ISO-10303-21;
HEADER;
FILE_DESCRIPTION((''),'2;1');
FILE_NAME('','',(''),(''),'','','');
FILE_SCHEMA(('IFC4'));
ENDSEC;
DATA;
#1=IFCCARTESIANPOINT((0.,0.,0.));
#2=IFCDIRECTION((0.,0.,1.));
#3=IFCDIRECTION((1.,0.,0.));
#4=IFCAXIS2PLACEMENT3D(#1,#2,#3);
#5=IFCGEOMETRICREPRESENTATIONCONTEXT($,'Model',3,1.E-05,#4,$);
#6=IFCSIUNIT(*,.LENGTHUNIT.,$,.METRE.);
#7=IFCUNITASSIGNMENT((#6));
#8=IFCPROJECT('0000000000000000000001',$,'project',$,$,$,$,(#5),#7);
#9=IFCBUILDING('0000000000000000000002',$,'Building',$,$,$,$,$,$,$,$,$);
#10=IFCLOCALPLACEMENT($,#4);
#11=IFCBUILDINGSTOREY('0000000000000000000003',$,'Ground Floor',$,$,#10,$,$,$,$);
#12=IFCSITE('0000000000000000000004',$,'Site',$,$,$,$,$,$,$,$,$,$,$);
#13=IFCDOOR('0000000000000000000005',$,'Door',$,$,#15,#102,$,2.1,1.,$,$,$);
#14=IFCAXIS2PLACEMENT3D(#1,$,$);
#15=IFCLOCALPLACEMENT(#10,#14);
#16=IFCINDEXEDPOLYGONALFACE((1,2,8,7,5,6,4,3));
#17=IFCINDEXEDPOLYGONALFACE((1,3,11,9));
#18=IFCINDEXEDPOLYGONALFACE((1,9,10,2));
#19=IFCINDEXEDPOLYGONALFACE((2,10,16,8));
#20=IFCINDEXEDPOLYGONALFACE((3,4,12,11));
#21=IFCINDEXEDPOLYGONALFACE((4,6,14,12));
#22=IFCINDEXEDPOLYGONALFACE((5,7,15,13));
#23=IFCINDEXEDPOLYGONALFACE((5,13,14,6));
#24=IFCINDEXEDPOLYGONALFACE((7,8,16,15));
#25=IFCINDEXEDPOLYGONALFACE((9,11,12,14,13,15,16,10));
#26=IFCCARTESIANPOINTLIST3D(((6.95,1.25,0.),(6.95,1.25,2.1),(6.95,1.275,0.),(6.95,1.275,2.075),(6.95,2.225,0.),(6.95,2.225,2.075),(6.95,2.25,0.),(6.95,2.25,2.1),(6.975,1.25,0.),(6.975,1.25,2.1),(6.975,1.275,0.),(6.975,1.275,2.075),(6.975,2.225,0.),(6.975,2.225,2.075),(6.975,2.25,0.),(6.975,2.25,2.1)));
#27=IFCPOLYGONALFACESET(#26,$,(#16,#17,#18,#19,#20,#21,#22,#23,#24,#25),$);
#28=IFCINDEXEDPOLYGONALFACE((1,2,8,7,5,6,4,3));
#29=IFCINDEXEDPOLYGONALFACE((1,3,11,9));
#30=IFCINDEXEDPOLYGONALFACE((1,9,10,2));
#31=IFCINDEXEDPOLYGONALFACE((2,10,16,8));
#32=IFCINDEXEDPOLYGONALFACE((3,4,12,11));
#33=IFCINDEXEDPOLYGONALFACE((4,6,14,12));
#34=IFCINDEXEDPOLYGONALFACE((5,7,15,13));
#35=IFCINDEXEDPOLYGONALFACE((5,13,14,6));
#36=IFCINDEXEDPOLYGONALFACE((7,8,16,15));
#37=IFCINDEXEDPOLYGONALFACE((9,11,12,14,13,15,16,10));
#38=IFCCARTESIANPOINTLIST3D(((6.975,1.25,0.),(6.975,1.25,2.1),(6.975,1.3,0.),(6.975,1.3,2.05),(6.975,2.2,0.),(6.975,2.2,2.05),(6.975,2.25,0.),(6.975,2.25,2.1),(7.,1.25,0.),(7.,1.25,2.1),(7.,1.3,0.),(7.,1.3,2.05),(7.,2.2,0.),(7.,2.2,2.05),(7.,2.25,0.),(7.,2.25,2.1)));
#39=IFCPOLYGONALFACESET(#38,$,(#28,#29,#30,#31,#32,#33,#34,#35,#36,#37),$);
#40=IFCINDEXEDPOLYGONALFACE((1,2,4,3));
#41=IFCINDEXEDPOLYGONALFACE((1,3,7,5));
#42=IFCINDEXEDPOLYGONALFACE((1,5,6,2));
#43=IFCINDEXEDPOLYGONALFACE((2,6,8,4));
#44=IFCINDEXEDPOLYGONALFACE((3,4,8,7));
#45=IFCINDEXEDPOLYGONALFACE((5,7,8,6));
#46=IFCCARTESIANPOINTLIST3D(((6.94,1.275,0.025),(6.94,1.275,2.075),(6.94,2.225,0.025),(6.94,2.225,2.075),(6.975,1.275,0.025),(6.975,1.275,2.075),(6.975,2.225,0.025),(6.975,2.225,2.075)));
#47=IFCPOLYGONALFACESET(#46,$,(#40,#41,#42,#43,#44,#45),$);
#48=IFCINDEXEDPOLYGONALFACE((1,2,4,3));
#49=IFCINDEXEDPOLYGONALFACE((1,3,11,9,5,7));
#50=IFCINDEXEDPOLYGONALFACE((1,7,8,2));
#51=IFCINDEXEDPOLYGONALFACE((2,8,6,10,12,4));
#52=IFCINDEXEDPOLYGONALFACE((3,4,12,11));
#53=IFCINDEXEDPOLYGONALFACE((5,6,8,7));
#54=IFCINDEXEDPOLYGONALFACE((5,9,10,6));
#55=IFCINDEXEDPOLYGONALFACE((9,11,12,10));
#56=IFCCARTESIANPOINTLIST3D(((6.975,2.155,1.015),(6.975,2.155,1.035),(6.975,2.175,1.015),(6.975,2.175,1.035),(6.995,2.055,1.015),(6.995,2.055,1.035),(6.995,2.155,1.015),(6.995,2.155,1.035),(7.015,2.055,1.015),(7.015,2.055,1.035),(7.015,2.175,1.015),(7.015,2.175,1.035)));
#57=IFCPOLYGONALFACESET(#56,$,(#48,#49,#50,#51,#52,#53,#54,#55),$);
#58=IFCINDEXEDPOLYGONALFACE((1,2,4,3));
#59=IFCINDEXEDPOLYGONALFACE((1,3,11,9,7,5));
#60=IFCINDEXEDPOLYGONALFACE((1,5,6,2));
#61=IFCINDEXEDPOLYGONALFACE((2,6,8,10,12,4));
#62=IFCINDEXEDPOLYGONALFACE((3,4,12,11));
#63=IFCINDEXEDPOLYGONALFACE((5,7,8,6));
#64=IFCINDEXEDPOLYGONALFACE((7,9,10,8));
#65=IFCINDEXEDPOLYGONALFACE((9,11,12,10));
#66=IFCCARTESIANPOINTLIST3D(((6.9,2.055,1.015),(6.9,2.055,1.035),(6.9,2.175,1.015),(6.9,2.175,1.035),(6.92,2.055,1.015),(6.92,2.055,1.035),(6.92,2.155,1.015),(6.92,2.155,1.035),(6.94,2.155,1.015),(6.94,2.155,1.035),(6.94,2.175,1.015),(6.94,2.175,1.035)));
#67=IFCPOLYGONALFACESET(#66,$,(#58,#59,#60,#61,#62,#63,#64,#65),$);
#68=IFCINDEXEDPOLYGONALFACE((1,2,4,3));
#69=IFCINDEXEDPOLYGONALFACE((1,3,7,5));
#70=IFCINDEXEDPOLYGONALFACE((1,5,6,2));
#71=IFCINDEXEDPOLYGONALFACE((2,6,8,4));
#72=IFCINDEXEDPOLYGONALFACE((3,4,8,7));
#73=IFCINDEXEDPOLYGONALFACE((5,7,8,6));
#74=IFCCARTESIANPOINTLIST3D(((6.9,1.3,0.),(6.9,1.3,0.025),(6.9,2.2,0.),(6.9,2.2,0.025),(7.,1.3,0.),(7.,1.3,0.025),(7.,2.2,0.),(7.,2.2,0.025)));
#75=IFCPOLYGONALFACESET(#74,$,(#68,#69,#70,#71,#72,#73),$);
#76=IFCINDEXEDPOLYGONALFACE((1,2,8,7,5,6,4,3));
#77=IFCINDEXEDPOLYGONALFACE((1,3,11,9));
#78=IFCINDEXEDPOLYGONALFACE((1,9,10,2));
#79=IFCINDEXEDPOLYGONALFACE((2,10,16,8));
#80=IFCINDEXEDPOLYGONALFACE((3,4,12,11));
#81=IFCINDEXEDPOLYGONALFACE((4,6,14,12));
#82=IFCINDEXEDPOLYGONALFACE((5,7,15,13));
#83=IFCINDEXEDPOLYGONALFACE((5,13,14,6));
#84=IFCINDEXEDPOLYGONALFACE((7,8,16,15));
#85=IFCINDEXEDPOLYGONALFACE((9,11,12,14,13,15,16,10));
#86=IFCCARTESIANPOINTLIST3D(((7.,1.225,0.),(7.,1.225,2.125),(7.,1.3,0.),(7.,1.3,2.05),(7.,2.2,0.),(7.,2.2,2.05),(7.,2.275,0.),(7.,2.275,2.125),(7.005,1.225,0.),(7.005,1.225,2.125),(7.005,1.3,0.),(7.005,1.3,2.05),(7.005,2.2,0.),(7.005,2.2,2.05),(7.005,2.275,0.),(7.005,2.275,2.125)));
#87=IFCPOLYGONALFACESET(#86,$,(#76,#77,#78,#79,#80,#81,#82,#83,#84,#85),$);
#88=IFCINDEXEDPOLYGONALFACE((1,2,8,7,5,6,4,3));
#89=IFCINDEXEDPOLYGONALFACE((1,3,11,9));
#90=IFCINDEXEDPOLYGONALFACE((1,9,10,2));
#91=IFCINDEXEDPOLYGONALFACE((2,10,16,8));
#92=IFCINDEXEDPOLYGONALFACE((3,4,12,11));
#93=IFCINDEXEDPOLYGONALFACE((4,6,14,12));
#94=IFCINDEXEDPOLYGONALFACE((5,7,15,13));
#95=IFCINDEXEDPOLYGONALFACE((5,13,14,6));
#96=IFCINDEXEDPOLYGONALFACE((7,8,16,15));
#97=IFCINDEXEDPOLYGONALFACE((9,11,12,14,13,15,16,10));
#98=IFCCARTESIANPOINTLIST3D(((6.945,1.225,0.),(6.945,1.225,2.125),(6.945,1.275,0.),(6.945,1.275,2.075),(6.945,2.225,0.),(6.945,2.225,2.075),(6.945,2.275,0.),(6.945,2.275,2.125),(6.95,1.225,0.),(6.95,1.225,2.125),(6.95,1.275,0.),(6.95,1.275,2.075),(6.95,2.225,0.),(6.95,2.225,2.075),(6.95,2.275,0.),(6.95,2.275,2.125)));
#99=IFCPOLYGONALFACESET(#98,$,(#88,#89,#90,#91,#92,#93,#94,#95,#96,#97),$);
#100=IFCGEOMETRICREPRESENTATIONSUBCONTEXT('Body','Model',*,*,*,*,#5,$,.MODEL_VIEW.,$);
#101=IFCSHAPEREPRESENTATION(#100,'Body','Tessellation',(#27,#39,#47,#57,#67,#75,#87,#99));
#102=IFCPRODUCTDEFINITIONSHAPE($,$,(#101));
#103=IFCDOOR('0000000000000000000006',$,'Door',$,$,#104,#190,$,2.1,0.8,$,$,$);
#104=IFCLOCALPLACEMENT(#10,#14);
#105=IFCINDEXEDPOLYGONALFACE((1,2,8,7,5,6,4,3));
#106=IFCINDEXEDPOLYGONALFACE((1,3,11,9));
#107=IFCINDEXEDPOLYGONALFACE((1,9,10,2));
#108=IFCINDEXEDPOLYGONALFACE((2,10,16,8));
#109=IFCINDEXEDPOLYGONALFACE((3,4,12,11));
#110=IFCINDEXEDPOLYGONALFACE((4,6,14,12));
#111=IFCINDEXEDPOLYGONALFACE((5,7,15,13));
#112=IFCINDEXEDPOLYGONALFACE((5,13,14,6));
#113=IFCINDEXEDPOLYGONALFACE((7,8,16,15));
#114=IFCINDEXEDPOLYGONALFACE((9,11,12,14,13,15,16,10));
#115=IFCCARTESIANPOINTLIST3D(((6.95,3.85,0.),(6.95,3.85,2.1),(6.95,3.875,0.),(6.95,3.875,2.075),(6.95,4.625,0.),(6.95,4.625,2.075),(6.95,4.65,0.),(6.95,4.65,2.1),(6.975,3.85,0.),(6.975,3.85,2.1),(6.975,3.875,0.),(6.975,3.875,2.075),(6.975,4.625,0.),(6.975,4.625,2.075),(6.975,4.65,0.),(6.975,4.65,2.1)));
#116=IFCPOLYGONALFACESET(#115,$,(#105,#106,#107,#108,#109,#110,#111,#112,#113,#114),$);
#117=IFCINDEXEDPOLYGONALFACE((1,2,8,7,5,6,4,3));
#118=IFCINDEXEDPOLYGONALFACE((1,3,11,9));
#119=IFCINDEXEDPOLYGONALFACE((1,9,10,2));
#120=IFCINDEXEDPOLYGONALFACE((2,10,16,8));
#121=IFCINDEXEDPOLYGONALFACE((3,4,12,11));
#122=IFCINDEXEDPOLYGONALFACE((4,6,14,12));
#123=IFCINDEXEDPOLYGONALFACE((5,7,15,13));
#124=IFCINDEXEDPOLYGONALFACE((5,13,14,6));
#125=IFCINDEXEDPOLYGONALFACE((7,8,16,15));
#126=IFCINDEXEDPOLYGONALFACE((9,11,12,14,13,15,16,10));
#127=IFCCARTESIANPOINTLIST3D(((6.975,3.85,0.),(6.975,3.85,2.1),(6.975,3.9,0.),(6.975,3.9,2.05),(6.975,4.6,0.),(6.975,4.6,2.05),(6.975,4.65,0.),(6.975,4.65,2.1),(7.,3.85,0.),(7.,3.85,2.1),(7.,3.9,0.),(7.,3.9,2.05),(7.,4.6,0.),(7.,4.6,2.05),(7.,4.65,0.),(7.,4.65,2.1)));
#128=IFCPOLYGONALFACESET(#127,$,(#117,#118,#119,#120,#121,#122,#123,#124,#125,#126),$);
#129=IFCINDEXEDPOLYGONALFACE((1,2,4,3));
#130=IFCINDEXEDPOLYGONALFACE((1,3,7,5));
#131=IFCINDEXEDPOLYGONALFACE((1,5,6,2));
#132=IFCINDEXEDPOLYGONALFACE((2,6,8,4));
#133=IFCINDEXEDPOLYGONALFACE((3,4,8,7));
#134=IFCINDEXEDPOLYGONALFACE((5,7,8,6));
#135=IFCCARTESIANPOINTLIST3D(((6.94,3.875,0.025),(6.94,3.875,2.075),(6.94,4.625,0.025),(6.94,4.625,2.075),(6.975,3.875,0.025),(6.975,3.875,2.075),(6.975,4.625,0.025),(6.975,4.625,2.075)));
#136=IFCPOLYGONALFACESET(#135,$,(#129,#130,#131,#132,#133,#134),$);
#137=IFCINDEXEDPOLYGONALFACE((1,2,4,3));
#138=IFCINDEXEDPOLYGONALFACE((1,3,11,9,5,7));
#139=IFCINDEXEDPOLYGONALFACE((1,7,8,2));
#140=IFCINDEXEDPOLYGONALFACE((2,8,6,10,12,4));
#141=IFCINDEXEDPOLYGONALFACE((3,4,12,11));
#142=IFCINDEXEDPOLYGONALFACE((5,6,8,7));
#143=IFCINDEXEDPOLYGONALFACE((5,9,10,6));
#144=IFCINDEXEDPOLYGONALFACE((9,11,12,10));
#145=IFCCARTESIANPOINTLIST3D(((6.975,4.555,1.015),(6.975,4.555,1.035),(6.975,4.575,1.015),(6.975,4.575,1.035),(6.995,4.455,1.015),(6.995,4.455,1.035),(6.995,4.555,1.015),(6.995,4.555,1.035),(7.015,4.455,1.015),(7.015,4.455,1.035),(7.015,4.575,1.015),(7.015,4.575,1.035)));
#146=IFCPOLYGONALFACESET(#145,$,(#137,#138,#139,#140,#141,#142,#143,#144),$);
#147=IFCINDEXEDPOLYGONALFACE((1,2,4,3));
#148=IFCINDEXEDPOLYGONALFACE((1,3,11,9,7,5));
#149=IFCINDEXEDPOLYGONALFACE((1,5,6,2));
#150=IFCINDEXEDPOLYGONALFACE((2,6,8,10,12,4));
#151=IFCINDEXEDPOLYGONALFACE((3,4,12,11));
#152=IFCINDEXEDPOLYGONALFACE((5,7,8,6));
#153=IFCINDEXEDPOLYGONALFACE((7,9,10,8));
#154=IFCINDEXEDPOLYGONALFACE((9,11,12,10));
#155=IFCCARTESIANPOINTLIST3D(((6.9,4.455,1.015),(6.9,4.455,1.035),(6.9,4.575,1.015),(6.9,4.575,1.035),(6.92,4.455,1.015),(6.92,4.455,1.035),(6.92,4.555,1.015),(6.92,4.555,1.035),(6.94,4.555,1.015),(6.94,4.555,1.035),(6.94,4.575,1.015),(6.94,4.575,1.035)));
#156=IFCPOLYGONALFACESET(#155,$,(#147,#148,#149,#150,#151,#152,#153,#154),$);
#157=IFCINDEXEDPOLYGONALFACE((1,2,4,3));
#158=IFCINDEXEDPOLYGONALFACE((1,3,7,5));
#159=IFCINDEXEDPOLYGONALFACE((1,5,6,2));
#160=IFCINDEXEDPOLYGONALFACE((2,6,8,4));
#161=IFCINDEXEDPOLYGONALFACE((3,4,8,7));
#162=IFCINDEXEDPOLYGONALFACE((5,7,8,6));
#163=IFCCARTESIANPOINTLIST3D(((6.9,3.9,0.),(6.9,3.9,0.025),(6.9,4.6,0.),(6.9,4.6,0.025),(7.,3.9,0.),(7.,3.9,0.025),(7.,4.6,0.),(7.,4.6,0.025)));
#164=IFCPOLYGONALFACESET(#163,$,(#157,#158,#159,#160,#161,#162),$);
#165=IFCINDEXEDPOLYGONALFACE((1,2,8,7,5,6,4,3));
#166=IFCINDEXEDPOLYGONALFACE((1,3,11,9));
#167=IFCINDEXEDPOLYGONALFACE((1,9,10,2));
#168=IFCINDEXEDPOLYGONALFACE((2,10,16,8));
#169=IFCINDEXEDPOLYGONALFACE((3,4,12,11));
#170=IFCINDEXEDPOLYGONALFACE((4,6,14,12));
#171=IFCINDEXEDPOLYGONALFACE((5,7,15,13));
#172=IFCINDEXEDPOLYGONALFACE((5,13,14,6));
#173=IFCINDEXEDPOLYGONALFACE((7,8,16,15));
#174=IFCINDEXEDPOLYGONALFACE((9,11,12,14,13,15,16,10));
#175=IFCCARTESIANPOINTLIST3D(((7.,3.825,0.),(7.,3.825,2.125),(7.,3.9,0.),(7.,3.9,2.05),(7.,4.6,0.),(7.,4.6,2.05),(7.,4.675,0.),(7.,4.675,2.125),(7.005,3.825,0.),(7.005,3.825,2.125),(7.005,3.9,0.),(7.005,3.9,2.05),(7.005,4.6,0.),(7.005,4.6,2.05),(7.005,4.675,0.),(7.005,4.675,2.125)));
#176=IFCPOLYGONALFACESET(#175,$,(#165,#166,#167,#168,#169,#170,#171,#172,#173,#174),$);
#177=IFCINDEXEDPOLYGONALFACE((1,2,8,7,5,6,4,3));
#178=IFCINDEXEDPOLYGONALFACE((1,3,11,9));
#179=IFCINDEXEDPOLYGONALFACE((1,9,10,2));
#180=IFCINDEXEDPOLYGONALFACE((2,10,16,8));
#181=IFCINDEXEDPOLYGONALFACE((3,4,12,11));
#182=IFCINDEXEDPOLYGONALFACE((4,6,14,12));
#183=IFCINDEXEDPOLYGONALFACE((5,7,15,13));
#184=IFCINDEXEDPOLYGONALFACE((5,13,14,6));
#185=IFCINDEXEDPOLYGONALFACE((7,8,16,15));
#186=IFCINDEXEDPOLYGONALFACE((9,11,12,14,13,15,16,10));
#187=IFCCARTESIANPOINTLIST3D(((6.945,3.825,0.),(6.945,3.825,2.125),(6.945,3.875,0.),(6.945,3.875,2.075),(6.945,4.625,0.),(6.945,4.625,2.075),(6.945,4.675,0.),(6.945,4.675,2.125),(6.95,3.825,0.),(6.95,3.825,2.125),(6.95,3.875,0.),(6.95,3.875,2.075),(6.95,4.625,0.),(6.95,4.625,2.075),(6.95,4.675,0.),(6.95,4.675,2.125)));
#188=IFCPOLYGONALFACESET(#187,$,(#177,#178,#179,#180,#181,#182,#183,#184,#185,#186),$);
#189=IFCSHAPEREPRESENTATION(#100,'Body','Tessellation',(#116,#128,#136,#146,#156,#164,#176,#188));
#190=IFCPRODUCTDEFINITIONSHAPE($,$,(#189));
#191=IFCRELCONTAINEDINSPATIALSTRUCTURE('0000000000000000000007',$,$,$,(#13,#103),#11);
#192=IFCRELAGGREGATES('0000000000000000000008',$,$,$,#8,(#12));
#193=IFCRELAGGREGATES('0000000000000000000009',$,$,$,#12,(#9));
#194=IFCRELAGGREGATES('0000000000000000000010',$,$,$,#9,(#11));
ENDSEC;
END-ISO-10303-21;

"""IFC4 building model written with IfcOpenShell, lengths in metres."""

from ifc_helpers import new_model, si_unit, frame, origin_with_axes, place, context, subcontext, project, spatial, line, indexed_curve, outline, extrude, element, save


model = new_model("IFC4")

# Units and contexts
model_context = context("Model", 3, precision=1e-05, world=origin_with_axes())
body_context = subcontext(model_context, "Body", "Model", "MODEL_VIEW")
ifc_project = project(units=[si_unit("LENGTHUNIT", "METRE")], contexts=[model_context])

# Site, building, storey
site = spatial("IfcSite", under=ifc_project, Name="Site")
building = spatial("IfcBuilding", under=site, Name="Building")
storey_placement = place(None, origin_with_axes())
storey = spatial("IfcBuildingStorey", under=building, at=storey_placement, Name="Ground Floor")

# Doors
door_1_placement = place(storey_placement, frame((7.0, 1.25, 0.0), z_axis=(0.0, 0.0, 1.0), x_axis=(0.0, 1.0, 0.0)))
element("IfcDoor", 1, at=door_1_placement, inside=storey, Name="Door", OverallHeight=2.1, OverallWidth=1.0, context=body_context, shape_type="SweptSolid", body=[
    extrude(outline(indexed_curve([(0.0, 0.0), (0.0, 2.1), (1.0, 2.1), (1.0, 0.0), (0.975, 0.0), (0.975, 2.075), (0.025, 2.075), (0.025, 0.0)], segments=[line(1, 2, 3, 4, 5, 6, 7, 8, 1)])), frame((0.0, 0.025, 0.0), z_axis=(0.0, -1.0, 0.0), x_axis=(1.0, 0.0, 0.0)), (0.0, 0.0, -1.0), 0.025),
    extrude(outline(indexed_curve([(0.0, 0.0), (0.0, 2.1), (1.0, 2.1), (1.0, 0.0), (0.95, 0.0), (0.95, 2.05), (0.05, 2.05), (0.05, 0.0)], segments=[line(1, 2, 3, 4, 5, 6, 7, 8, 1)])), frame((0.0, 0.0, 0.0), z_axis=(0.0, -1.0, 0.0), x_axis=(1.0, 0.0, 0.0)), (0.0, 0.0, -1.0), 0.025),
    extrude(outline(indexed_curve([(0.0, 0.0), (0.95, 0.0), (0.95, 0.035), (0.0, 0.035)], segments=[line(1, 2, 3, 4, 1)])), frame((0.025, 0.025, 0.025), z_axis=(0.0, 0.0, 1.0), x_axis=(1.0, 0.0, 0.0)), (0.0, 0.0, 1.0), 2.05),
    extrude(outline(indexed_curve([(0.0, 0.0), (0.0, -0.04), (-0.12, -0.04), (-0.12, -0.02), (-0.02, -0.02), (-0.02, 0.0)], segments=[line(1, 2, 3, 4, 5, 6, 1)])), frame((0.925, 0.025, 1.015), z_axis=(0.0, 0.0, 1.0), x_axis=(1.0, 0.0, 0.0)), (0.0, 0.0, 1.0), 0.02),
    extrude(outline(indexed_curve([(0.0, 0.0), (0.0, 0.04), (-0.12, 0.04), (-0.12, 0.02), (-0.02, 0.02), (-0.02, 0.0)], segments=[line(1, 2, 3, 4, 5, 6, 1)])), frame((0.925, 0.06, 1.015), z_axis=(0.0, 0.0, 1.0), x_axis=(1.0, 0.0, 0.0)), (0.0, 0.0, 1.0), 0.02),
    extrude(outline(indexed_curve([(0.0, 0.0), (0.9, 0.0), (0.9, 0.1), (0.0, 0.1)], segments=[line(1, 2, 3, 4, 1)])), frame((0.05, 0.0, 0.0), z_axis=(0.0, 0.0, 1.0), x_axis=(1.0, 0.0, 0.0)), (0.0, 0.0, 1.0), 0.025),
    extrude(outline(indexed_curve([(0.0, 0.0), (0.0, 2.125), (1.05, 2.125), (1.05, 0.0), (0.975, 0.0), (0.975, 2.05), (0.075, 2.05), (0.075, 0.0)], segments=[line(1, 2, 3, 4, 5, 6, 7, 8, 1)])), frame((-0.025, -0.005, 0.0), z_axis=(0.0, -1.0, 0.0), x_axis=(1.0, 0.0, 0.0)), (0.0, 0.0, -1.0), 0.005),
    extrude(outline(indexed_curve([(0.0, 0.0), (0.0, 2.125), (1.05, 2.125), (1.05, 0.0), (1.0, 0.0), (1.0, 2.075), (0.05, 2.075), (0.05, 0.0)], segments=[line(1, 2, 3, 4, 5, 6, 7, 8, 1)])), frame((-0.025, 0.05, 0.0), z_axis=(0.0, -1.0, 0.0), x_axis=(1.0, 0.0, 0.0)), (0.0, 0.0, -1.0), 0.005),
])
door_2_placement = place(storey_placement, frame((7.0, 3.85, 0.0), z_axis=(0.0, 0.0, 1.0), x_axis=(0.0, 1.0, 0.0)))
element("IfcDoor", 2, at=door_2_placement, inside=storey, Name="Door", OverallHeight=2.1, OverallWidth=0.8, context=body_context, shape_type="SweptSolid", body=[
    extrude(outline(indexed_curve([(0.0, 0.0), (0.0, 2.1), (0.8, 2.1), (0.8, 0.0), (0.775, 0.0), (0.775, 2.075), (0.025, 2.075), (0.025, 0.0)], segments=[line(1, 2, 3, 4, 5, 6, 7, 8, 1)])), frame((0.0, 0.025, 0.0), z_axis=(0.0, -1.0, 0.0), x_axis=(1.0, 0.0, 0.0)), (0.0, 0.0, -1.0), 0.025),
    extrude(outline(indexed_curve([(0.0, 0.0), (0.0, 2.1), (0.8, 2.1), (0.8, 0.0), (0.75, 0.0), (0.75, 2.05), (0.05, 2.05), (0.05, 0.0)], segments=[line(1, 2, 3, 4, 5, 6, 7, 8, 1)])), frame((0.0, 0.0, 0.0), z_axis=(0.0, -1.0, 0.0), x_axis=(1.0, 0.0, 0.0)), (0.0, 0.0, -1.0), 0.025),
    extrude(outline(indexed_curve([(0.0, 0.0), (0.75, 0.0), (0.75, 0.035), (0.0, 0.035)], segments=[line(1, 2, 3, 4, 1)])), frame((0.025, 0.025, 0.025), z_axis=(0.0, 0.0, 1.0), x_axis=(1.0, 0.0, 0.0)), (0.0, 0.0, 1.0), 2.05),
    extrude(outline(indexed_curve([(0.0, 0.0), (0.0, -0.04), (-0.12, -0.04), (-0.12, -0.02), (-0.02, -0.02), (-0.02, 0.0)], segments=[line(1, 2, 3, 4, 5, 6, 1)])), frame((0.725, 0.025, 1.015), z_axis=(0.0, 0.0, 1.0), x_axis=(1.0, 0.0, 0.0)), (0.0, 0.0, 1.0), 0.02),
    extrude(outline(indexed_curve([(0.0, 0.0), (0.0, 0.04), (-0.12, 0.04), (-0.12, 0.02), (-0.02, 0.02), (-0.02, 0.0)], segments=[line(1, 2, 3, 4, 5, 6, 1)])), frame((0.725, 0.06, 1.015), z_axis=(0.0, 0.0, 1.0), x_axis=(1.0, 0.0, 0.0)), (0.0, 0.0, 1.0), 0.02),
    extrude(outline(indexed_curve([(0.0, 0.0), (0.7, 0.0), (0.7, 0.1), (0.0, 0.1)], segments=[line(1, 2, 3, 4, 1)])), frame((0.05, 0.0, 0.0), z_axis=(0.0, 0.0, 1.0), x_axis=(1.0, 0.0, 0.0)), (0.0, 0.0, 1.0), 0.025),
    extrude(outline(indexed_curve([(0.0, 0.0), (0.0, 2.125), (0.85, 2.125), (0.85, 0.0), (0.775, 0.0), (0.775, 2.05), (0.075, 2.05), (0.075, 0.0)], segments=[line(1, 2, 3, 4, 5, 6, 7, 8, 1)])), frame((-0.025, -0.005, 0.0), z_axis=(0.0, -1.0, 0.0), x_axis=(1.0, 0.0, 0.0)), (0.0, 0.0, -1.0), 0.005),
    extrude(outline(indexed_curve([(0.0, 0.0), (0.0, 2.125), (0.85, 2.125), (0.85, 0.0), (0.8, 0.0), (0.8, 2.075), (0.05, 2.075), (0.05, 0.0)], segments=[line(1, 2, 3, 4, 5, 6, 7, 8, 1)])), frame((-0.025, 0.05, 0.0), z_axis=(0.0, -1.0, 0.0), x_axis=(1.0, 0.0, 0.0)), (0.0, 0.0, -1.0), 0.005),
])

save(model, "model.ifc")
